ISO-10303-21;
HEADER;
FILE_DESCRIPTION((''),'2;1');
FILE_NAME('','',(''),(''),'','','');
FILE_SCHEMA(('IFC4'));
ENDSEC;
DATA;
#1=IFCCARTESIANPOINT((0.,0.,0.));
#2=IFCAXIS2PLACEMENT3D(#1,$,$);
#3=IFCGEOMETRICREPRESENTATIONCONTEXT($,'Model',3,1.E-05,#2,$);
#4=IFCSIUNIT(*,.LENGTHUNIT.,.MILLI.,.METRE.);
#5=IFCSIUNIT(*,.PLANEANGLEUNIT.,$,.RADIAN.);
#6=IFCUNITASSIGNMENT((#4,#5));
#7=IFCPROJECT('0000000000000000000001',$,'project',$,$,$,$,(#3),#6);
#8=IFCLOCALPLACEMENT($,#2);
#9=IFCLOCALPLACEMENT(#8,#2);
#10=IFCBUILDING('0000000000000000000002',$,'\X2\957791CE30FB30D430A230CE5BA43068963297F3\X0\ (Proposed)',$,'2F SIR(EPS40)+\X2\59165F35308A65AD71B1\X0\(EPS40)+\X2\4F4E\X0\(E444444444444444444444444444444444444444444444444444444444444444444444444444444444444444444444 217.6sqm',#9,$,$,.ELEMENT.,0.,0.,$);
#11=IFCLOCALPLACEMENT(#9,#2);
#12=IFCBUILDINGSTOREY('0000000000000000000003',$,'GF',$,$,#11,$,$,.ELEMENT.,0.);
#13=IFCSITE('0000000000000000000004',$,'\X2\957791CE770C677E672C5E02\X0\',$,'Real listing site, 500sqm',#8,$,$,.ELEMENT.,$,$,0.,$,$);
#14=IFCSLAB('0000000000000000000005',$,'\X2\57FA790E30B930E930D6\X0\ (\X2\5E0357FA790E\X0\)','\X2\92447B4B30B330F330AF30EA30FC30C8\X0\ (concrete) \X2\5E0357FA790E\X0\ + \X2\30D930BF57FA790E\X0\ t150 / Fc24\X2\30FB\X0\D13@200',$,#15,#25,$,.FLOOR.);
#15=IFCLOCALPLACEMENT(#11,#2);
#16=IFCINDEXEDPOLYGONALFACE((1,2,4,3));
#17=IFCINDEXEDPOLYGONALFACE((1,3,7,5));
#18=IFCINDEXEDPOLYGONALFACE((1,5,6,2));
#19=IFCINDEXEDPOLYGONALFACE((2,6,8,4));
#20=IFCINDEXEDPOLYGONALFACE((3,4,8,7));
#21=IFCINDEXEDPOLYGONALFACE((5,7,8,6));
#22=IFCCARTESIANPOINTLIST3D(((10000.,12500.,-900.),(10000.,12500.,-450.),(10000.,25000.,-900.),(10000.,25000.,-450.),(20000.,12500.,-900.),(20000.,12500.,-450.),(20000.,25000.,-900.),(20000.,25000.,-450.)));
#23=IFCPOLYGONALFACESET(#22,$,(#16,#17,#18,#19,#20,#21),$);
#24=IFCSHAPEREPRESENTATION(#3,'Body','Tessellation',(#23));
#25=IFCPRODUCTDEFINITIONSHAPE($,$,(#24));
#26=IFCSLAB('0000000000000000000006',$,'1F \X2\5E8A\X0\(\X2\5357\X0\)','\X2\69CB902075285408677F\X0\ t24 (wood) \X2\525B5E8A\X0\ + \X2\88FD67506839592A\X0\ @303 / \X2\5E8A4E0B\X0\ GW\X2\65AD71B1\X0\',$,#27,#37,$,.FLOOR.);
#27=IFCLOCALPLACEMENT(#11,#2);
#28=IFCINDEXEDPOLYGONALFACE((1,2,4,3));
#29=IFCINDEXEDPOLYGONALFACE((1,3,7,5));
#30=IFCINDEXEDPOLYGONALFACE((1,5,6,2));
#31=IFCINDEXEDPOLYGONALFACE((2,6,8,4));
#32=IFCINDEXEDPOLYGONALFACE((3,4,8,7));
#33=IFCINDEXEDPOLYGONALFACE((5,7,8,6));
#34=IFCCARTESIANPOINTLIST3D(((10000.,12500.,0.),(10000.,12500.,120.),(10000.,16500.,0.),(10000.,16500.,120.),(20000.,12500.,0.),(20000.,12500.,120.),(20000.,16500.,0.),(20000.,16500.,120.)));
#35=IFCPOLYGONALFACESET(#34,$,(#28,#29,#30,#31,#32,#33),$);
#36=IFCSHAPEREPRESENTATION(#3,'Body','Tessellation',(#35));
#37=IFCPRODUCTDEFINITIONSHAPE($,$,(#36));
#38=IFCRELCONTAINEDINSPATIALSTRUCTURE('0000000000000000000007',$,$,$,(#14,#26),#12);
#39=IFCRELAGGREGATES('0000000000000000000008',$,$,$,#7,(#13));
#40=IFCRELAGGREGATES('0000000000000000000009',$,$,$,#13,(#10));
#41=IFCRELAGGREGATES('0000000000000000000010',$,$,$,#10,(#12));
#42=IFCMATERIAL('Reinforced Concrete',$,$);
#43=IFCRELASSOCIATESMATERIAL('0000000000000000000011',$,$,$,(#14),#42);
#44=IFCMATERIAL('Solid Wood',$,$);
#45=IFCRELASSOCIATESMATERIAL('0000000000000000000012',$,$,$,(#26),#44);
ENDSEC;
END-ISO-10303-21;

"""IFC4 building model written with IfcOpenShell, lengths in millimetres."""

from ifc_helpers import new_model, si_unit, frame, frame_2d, origin, place, context, project, spatial, rectangle, extrude, material, element, save


model = new_model("IFC4")

# Units and contexts
model_context = context("Model", 3, precision=1e-05, world=origin())
ifc_project = project(units=[si_unit("LENGTHUNIT", "METRE", prefix="MILLI"), si_unit("PLANEANGLEUNIT", "RADIAN")], contexts=[model_context])

# Site, building, storey
site_placement = place(None, origin())
site = spatial("IfcSite", under=ifc_project, at=site_placement, Name="長野県松本市", ObjectType="Real listing site, 500sqm", CompositionType="ELEMENT", RefElevation=0.0)
building_placement = place(site_placement, origin())
building = spatial("IfcBuilding", under=site, at=building_placement, Name="長野・ピアノ室と防音 (Proposed)", ObjectType="2F SIR(EPS40)+外張り断熱(EPS40)+低(E444444444444444444444444444444444444444444444444444444444444444444444444444444444444444444444 217.6sqm", CompositionType="ELEMENT", ElevationOfRefHeight=0.0, ElevationOfTerrain=0.0)
storey_placement = place(building_placement, origin())
storey = spatial("IfcBuildingStorey", under=building, at=storey_placement, Name="GF", CompositionType="ELEMENT", Elevation=0.0)

# Shared definitions
ifc_material_1 = material(Name="Solid Wood")

# Slabs
ifc_material_2 = material(Name="Reinforced Concrete")
slab_1_placement = place(storey_placement, frame((5000.0, 6250.0, -450.0)))
element("IfcSlab", 1, at=slab_1_placement, inside=storey, material=ifc_material_2, Name="基礎スラブ (布基礎)", Description="鉄筋コンクリート (concrete) 布基礎 + ベタ基礎 t150 / Fc24・D13@200", PredefinedType="FLOOR", context=model_context, shape_type="SweptSolid", body=[
    extrude(rectangle(XDim=10000.0, YDim=12500.0, at=frame_2d((5000.0, 6250.0))), frame((5000.0, 6250.0, -450.0)), (0.0, 0.0, 1.0), 450.0),
])
slab_2_placement = place(storey_placement, frame((5000.0, 6250.0, 0.0)))
element("IfcSlab", 2, at=slab_2_placement, inside=storey, material=ifc_material_1, Name="1F 床(南)", Description="構造用合板 t24 (wood) 剛床 + 製材根太 @303 / 床下 GW断熱", PredefinedType="FLOOR", context=model_context, shape_type="SweptSolid", body=[
    extrude(rectangle(XDim=10000.0, YDim=4000.0, at=frame_2d((5000.0, 2000.0))), frame((5000.0, 6250.0, 0.0)), (0.0, 0.0, 1.0), 120.0),
])

save(model, "model.ifc")
